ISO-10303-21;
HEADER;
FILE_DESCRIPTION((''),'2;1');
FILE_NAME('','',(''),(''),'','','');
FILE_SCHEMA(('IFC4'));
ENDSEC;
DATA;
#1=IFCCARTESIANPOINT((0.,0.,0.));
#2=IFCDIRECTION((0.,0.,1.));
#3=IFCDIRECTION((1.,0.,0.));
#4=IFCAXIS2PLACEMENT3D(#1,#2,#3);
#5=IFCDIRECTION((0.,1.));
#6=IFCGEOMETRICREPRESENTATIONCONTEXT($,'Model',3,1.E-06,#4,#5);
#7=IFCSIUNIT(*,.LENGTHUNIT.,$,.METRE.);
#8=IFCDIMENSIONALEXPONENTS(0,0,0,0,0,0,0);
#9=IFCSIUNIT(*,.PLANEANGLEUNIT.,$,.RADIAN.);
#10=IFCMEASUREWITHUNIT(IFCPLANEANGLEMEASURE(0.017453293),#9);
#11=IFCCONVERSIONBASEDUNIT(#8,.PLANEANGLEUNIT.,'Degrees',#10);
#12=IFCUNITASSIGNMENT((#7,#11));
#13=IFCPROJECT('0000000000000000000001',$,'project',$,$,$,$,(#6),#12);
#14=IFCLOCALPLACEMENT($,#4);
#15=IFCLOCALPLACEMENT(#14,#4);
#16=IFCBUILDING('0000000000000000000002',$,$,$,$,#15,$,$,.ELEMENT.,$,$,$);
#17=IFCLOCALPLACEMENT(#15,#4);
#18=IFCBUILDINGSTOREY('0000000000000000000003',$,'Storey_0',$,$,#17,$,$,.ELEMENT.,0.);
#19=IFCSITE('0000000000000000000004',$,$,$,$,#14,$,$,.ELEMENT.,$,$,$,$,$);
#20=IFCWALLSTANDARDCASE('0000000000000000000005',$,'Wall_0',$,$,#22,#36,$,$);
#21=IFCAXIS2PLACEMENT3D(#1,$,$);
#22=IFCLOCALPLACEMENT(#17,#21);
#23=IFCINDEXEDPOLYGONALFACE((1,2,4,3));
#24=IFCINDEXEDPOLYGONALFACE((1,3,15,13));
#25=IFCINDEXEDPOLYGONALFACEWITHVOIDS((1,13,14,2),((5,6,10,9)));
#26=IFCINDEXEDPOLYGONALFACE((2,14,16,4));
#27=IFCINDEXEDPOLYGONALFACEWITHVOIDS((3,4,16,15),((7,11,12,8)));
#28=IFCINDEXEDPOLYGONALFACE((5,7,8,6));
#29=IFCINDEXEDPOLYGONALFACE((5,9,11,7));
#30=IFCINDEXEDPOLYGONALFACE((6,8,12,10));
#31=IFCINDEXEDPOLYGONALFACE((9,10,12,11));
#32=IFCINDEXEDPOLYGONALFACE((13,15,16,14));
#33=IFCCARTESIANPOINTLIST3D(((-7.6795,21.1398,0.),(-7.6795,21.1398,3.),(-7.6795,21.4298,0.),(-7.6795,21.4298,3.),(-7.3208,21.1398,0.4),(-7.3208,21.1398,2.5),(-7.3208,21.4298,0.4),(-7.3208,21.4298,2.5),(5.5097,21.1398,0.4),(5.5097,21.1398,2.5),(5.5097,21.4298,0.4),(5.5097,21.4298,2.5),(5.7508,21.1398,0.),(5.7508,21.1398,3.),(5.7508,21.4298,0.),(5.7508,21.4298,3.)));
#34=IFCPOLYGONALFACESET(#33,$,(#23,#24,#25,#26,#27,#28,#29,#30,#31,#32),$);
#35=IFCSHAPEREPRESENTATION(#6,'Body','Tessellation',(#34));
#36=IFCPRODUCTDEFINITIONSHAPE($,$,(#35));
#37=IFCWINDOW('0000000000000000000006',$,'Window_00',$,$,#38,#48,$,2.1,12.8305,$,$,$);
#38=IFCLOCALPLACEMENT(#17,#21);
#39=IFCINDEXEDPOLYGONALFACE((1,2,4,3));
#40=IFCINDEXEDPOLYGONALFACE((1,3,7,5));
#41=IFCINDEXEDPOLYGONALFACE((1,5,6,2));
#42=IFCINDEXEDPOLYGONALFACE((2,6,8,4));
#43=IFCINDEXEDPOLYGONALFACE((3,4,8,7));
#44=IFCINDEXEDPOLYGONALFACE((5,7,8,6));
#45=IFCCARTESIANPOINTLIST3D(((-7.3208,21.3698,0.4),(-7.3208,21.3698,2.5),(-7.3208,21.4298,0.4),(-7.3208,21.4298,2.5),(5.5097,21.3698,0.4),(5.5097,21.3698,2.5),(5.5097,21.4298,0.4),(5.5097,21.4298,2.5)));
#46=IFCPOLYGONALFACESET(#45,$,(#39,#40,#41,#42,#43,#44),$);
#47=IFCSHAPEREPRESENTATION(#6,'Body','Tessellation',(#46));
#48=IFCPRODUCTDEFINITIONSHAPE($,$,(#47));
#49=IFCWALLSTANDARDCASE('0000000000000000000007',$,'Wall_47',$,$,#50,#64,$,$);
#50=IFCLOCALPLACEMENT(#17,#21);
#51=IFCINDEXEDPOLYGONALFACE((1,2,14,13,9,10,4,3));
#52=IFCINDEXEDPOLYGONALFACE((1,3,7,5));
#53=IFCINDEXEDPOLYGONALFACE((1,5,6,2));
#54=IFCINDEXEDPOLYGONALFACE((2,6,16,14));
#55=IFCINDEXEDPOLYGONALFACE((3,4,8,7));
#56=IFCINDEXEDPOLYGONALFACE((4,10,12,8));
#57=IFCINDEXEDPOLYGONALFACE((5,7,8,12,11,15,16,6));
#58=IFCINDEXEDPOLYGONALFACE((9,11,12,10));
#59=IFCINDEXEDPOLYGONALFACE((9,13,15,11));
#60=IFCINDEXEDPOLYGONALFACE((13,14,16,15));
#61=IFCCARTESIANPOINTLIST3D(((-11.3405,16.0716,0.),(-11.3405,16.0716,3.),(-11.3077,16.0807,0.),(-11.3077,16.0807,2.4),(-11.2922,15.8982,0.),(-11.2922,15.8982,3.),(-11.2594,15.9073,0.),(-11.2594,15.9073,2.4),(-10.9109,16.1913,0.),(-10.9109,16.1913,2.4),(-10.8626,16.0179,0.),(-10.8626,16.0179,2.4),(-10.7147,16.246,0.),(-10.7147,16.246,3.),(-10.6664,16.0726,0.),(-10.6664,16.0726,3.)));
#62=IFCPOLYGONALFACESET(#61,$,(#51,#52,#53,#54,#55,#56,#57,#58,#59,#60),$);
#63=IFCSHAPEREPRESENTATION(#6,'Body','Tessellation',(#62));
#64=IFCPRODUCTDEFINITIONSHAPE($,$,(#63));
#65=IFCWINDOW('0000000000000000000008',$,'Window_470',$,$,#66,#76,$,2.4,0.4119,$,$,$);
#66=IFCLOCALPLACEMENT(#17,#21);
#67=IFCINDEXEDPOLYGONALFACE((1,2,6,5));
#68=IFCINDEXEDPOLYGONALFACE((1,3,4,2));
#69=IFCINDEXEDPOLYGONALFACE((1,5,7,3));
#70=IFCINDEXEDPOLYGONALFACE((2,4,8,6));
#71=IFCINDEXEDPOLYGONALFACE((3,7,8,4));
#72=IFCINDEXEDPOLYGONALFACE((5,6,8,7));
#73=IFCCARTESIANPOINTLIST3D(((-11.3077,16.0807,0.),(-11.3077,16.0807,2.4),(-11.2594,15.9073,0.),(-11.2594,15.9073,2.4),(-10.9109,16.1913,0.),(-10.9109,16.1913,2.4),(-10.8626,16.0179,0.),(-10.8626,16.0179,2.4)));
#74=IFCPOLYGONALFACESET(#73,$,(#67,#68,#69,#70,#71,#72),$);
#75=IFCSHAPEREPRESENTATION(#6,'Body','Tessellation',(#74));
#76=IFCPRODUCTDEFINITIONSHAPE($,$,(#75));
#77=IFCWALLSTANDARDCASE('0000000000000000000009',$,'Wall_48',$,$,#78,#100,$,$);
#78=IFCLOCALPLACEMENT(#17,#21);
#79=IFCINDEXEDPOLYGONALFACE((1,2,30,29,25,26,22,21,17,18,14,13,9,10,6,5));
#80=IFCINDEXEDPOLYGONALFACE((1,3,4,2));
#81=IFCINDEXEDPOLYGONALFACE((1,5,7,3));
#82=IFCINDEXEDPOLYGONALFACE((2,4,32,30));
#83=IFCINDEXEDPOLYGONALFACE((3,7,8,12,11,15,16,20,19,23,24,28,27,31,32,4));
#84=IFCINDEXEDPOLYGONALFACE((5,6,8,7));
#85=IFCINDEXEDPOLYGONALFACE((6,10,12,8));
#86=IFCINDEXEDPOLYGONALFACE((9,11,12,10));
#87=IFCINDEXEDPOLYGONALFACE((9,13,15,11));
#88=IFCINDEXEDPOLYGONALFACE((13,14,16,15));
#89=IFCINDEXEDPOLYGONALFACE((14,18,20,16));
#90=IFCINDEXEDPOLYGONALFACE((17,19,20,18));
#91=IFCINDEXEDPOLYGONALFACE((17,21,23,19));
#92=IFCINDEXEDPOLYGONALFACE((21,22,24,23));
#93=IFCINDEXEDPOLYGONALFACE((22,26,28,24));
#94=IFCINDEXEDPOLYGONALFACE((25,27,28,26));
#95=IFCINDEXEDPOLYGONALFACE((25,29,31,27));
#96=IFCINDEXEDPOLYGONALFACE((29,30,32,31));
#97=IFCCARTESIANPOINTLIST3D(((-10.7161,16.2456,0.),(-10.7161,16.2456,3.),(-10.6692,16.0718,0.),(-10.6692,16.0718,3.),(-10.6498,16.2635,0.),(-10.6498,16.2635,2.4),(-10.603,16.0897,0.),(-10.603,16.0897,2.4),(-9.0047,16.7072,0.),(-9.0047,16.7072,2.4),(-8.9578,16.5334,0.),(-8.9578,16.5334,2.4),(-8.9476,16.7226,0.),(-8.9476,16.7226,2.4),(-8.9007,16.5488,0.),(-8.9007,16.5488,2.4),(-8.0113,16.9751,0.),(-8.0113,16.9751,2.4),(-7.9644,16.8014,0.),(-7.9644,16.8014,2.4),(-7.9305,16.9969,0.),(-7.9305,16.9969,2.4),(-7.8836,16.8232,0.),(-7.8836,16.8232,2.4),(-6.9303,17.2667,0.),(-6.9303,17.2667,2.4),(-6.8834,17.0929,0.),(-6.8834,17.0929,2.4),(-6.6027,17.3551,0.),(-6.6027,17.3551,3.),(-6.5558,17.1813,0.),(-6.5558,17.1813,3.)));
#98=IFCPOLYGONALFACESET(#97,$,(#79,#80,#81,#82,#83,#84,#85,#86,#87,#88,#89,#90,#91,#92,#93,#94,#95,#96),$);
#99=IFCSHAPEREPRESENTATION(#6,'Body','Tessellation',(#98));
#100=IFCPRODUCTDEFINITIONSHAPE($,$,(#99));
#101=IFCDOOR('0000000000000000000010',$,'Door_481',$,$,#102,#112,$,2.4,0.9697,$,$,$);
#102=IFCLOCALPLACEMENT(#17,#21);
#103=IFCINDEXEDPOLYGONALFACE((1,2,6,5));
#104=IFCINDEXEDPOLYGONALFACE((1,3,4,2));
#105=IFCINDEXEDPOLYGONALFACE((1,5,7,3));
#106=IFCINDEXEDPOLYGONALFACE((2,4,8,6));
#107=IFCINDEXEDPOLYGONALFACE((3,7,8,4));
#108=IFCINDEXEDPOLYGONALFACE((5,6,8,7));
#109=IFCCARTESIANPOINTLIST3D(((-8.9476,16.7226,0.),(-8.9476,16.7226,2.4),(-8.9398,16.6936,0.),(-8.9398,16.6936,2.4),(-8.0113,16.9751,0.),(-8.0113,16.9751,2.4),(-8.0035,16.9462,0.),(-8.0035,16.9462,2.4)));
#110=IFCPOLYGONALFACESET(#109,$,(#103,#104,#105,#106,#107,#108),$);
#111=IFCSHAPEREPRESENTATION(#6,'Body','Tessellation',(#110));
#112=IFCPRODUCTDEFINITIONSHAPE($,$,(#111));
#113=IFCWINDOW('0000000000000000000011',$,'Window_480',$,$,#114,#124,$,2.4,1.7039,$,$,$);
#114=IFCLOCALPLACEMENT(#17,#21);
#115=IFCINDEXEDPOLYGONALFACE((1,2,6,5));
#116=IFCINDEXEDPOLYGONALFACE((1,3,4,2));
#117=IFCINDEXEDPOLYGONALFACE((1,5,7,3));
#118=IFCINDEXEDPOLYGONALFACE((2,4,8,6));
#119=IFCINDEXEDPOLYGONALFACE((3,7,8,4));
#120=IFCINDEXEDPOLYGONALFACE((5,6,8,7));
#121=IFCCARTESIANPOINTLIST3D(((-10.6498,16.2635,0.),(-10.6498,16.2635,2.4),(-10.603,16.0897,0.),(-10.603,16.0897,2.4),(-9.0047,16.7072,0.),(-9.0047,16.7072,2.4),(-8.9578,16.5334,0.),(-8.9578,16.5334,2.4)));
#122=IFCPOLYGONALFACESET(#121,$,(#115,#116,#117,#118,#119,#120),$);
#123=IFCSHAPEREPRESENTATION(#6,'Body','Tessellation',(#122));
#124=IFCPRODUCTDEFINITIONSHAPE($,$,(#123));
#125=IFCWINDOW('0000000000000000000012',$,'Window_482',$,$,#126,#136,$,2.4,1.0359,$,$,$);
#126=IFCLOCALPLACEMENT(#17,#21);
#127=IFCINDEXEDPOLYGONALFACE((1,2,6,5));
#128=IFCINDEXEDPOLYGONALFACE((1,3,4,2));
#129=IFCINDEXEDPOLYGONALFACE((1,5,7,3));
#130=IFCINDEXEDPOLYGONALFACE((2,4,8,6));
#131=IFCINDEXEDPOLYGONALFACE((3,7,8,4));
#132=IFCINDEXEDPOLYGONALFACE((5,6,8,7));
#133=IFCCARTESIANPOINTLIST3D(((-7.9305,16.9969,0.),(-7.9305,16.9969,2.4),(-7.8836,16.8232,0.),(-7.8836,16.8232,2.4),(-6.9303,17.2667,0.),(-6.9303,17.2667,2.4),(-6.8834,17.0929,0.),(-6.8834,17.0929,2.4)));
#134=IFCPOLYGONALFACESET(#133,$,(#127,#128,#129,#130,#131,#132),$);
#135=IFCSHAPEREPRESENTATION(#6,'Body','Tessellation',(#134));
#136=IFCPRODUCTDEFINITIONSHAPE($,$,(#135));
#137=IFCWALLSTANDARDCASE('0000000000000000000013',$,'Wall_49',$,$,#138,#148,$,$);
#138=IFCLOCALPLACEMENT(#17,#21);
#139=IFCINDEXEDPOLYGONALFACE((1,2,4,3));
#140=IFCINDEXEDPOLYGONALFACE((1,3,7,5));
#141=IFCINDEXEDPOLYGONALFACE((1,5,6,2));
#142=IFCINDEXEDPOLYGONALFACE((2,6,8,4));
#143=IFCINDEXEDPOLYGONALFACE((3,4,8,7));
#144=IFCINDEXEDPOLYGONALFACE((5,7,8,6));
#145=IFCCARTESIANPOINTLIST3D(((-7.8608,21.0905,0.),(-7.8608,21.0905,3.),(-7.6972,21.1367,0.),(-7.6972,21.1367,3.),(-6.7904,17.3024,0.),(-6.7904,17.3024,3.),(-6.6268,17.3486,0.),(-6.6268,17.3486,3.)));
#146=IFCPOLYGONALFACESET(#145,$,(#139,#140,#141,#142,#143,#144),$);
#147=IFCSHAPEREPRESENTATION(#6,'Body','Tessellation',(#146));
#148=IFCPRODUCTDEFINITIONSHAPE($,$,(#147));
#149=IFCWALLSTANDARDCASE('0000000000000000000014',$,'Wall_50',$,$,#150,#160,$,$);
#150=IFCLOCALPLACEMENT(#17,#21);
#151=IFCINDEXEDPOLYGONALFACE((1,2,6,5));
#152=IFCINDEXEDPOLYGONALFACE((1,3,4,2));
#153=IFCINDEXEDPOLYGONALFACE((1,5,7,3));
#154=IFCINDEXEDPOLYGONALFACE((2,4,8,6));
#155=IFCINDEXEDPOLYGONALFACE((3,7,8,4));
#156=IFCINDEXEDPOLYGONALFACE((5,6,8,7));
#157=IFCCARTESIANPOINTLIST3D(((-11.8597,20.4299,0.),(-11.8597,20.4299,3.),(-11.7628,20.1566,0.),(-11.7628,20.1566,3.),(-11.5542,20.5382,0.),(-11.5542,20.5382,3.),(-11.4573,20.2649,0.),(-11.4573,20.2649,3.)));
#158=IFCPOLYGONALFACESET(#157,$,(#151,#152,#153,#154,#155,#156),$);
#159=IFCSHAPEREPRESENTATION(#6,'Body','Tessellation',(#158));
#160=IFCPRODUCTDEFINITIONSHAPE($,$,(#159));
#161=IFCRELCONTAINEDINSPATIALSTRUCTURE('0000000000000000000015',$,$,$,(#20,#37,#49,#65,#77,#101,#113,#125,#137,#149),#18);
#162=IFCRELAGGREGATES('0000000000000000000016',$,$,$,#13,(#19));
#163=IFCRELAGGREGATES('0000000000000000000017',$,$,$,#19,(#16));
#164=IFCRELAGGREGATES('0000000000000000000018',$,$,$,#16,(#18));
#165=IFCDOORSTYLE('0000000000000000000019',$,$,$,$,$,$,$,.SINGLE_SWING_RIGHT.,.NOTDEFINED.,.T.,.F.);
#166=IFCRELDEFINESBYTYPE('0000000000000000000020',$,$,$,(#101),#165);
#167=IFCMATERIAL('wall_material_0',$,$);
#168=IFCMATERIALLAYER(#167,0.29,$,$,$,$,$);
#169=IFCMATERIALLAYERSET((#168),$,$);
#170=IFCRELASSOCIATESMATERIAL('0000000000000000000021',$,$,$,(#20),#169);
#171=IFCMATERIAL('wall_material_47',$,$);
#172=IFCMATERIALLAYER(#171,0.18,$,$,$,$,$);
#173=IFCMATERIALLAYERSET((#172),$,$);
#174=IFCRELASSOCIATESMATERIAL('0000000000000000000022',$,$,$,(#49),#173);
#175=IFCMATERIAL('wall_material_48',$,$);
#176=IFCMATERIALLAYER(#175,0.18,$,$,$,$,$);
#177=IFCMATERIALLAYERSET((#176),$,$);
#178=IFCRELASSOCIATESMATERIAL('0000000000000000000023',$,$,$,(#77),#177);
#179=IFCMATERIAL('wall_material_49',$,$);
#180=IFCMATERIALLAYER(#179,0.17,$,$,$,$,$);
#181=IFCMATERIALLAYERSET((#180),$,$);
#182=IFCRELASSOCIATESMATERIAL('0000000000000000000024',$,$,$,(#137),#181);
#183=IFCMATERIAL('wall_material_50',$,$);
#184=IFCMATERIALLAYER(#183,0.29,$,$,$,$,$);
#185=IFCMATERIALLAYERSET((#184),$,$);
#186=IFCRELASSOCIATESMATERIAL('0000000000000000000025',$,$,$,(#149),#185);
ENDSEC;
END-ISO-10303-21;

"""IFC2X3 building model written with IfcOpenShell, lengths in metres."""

from ifc_helpers import new_model, entity, si_unit, converted_unit, direction, frame, frame_2d, origin_with_axes, place, context, project, spatial, polyline, rectangle, outline, extrude, material, layer, layer_set, layer_usage, type_object, element, fill, save


model = new_model("IFC2X3")

# Units and contexts
model_context = context("Model", 3, precision=1e-06, world=origin_with_axes(), true_north=direction((0.0, 1.0)))
ifc_project = project(units=[si_unit("LENGTHUNIT", "METRE"), converted_unit("PLANEANGLEUNIT", "Degrees", entity("IfcPlaneAngleMeasure", 0.017453293), si_unit("PLANEANGLEUNIT", "RADIAN"), dimensions=[0, 0, 0, 0, 0, 0, 0])], contexts=[model_context])

# Site, building, storey
site_placement = place(None, origin_with_axes())
site = spatial("IfcSite", under=ifc_project, at=site_placement, CompositionType="ELEMENT")
building_placement = place(site_placement, origin_with_axes())
building = spatial("IfcBuilding", under=site, at=building_placement, CompositionType="ELEMENT")
storey_placement = place(building_placement, origin_with_axes())
storey = spatial("IfcBuildingStorey", under=building, at=storey_placement, Name="Storey_0", CompositionType="ELEMENT", Elevation=0.0)

# Walls, openings, windows
ifc_material_1 = material(Name="wall_material_0")
ifc_layer_1 = layer(ifc_material_1, 0.29)
ifc_layer_set_1 = layer_set([ifc_layer_1])
ifc_layer_usage_1 = layer_usage(ifc_layer_set_1, "AXIS2", "NEGATIVE", 0.0)
wall_1_placement = place(storey_placement, frame((-7.6795, 21.4298, 0.0), z_axis=(0.0, 0.0, 1.0), x_axis=(1.0, 0.0, 0.0)))
wall_1 = element("IfcWallStandardCase", 1, at=wall_1_placement, inside=storey, material=ifc_layer_usage_1, Name="Wall_0", context=model_context, shape_type="SweptSolid", body=[
    extrude(outline(polyline([(0.0, 0.0), (13.4303, 0.0), (13.4303, -0.29), (0.0, -0.29), (0.0, 0.0)])), origin_with_axes(), (0.0, 0.0, 1.0), 3.0),
])
opening_1_placement = place(wall_1_placement, frame((0.3587, 0.0, 0.4), z_axis=(0.0, 0.0, 1.0), x_axis=(1.0, 0.0, 0.0)))
opening_1 = element("IfcOpeningElement", 2, at=opening_1_placement, cuts=wall_1, context=model_context, shape_type="SweptSolid", body=[
    extrude(rectangle(XDim=12.8305, YDim=2.1, at=frame_2d((1.05, -6.4152), x_axis=(0.0, 1.0))), frame((0.0, 0.01, 0.0), z_axis=(0.0, -1.0, 0.0), x_axis=(0.0, 0.0, 1.0)), (0.0, 0.0, 1.0), 0.31),
])
window_1_placement = place(storey_placement, frame((0.0, 0.0, 0.4), z_axis=(0.0, 0.0, 1.0), x_axis=(1.0, 0.0, 0.0)))
window_1 = element("IfcWindow", 3, at=window_1_placement, inside=storey, Name="Window_00", OverallHeight=2.1, OverallWidth=12.8305, context=model_context, shape_type="SweptSolid", body=[
    extrude(outline(polyline([(-7.3208, 21.4298), (5.5097, 21.4298), (5.5097, 21.3698), (-7.3208, 21.3698), (-7.3208, 21.4298)])), origin_with_axes(), (0.0, 0.0, 1.0), 2.1),
])
fill(opening_1, window_1)
ifc_material_2 = material(Name="wall_material_47")
ifc_layer_2 = layer(ifc_material_2, 0.18)
ifc_layer_set_2 = layer_set([ifc_layer_2])
ifc_layer_usage_2 = layer_usage(ifc_layer_set_2, "AXIS2", "POSITIVE", 0.0)
wall_2_placement = place(storey_placement, frame((-11.2922, 15.8982, 0.0), z_axis=(0.0, 0.0, 1.0), x_axis=(0.96329, 0.268463, 0.0)))
wall_2 = element("IfcWallStandardCase", 4, at=wall_2_placement, inside=storey, material=ifc_layer_usage_2, Name="Wall_47", context=model_context, shape_type="SweptSolid", body=[
    extrude(outline(polyline([(0.0, 0.18), (0.6497, 0.18), (0.6497, 0.0), (0.0, 0.0), (0.0, 0.18)])), origin_with_axes(), (0.0, 0.0, 1.0), 3.0),
])
opening_2_placement = place(wall_2_placement, frame((0.0341, 0.18, 0.0), z_axis=(0.0, 0.0, 1.0), x_axis=(1.0, 0.0, 0.0)))
opening_2 = element("IfcOpeningElement", 5, at=opening_2_placement, cuts=wall_2, context=model_context, shape_type="SweptSolid", body=[
    extrude(rectangle(XDim=0.4119, YDim=2.4, at=frame_2d((1.2, -0.2059), x_axis=(0.0, 1.0))), frame((0.0, 0.01, 0.0), z_axis=(0.0, -1.0, 0.0), x_axis=(0.0, 0.0, 1.0)), (0.0, 0.0, 1.0), 0.2),
])
window_2_placement = place(storey_placement, origin_with_axes())
window_2 = element("IfcWindow", 6, at=window_2_placement, inside=storey, Name="Window_470", OverallHeight=2.4, OverallWidth=0.4119, context=model_context, shape_type="SweptSolid", body=[
    extrude(outline(polyline([(-11.3077, 16.0807), (-10.9109, 16.1913), (-10.8626, 16.0179), (-11.2594, 15.9073), (-11.3077, 16.0807)])), origin_with_axes(), (0.0, 0.0, 1.0), 2.4),
])
fill(opening_2, window_2)

# Wall, openings, door, windows
ifc_material_3 = material(Name="wall_material_48")
ifc_layer_3 = layer(ifc_material_3, 0.18)
ifc_layer_set_3 = layer_set([ifc_layer_3])
ifc_layer_usage_3 = layer_usage(ifc_layer_set_3, "AXIS2", "POSITIVE", 0.0)
wall_3_placement = place(storey_placement, frame((-10.6692, 16.0718, 0.0), z_axis=(0.0, 0.0, 1.0), x_axis=(0.965495, 0.260421, 0.0)))
wall_3 = element("IfcWallStandardCase", 7, at=wall_3_placement, inside=storey, material=ifc_layer_usage_3, Name="Wall_48", context=model_context, shape_type="SweptSolid", body=[
    extrude(outline(polyline([(0.0, 0.18), (4.2605, 0.18), (4.2605, 0.0), (0.0, 0.0), (0.0, 0.18)])), origin_with_axes(), (0.0, 0.0, 1.0), 3.0),
])
opening_3_placement = place(wall_3_placement, frame((0.0687, 0.18, 0.0), z_axis=(0.0, 0.0, 1.0), x_axis=(1.0, 0.0, 0.0)))
opening_3 = element("IfcOpeningElement", 8, at=opening_3_placement, cuts=wall_3, context=model_context, shape_type="SweptSolid", body=[
    extrude(rectangle(XDim=1.7039, YDim=2.4, at=frame_2d((1.2, -0.852), x_axis=(0.0, 1.0))), frame((0.0, 0.01, 0.0), z_axis=(0.0, -1.0, 0.0), x_axis=(0.0, 0.0, 1.0)), (0.0, 0.0, 1.0), 0.2),
])
opening_4_placement = place(wall_3_placement, frame((1.8318, 0.18, 0.0), z_axis=(0.0, 0.0, 1.0), x_axis=(1.0, 0.0, 0.0)))
opening_4 = element("IfcOpeningElement", 9, at=opening_4_placement, cuts=wall_3, context=model_context, shape_type="SweptSolid", body=[
    extrude(rectangle(XDim=0.9697, YDim=2.4, at=frame_2d((1.2, -0.4849), x_axis=(0.0, 1.0))), frame((0.0, 0.01, 0.0), z_axis=(0.0, -1.0, 0.0), x_axis=(0.0, 0.0, 1.0)), (0.0, 0.0, 1.0), 0.2),
])
opening_5_placement = place(wall_3_placement, frame((2.8852, 0.18, 0.0), z_axis=(0.0, 0.0, 1.0), x_axis=(1.0, 0.0, 0.0)))
opening_5 = element("IfcOpeningElement", 10, at=opening_5_placement, cuts=wall_3, context=model_context, shape_type="SweptSolid", body=[
    extrude(rectangle(XDim=1.0359, YDim=2.4, at=frame_2d((1.2, -0.518), x_axis=(0.0, 1.0))), frame((0.0, 0.01, 0.0), z_axis=(0.0, -1.0, 0.0), x_axis=(0.0, 0.0, 1.0)), (0.0, 0.0, 1.0), 0.2),
])
door_style_1 = type_object("IfcDoorStyle", ConstructionType="NOTDEFINED", OperationType="SINGLE_SWING_RIGHT", ParameterTakesPrecedence=True, Sizeable=False)
door_1_placement = place(storey_placement, origin_with_axes())
door_1 = element("IfcDoor", 11, at=door_1_placement, inside=storey, type_object=door_style_1, Name="Door_481", OverallHeight=2.4, OverallWidth=0.9697, context=model_context, shape_type="SweptSolid", body=[
    extrude(outline(polyline([(-8.9476, 16.7226), (-8.0113, 16.9751), (-8.0035, 16.9462), (-8.9398, 16.6936), (-8.9476, 16.7226)])), origin_with_axes(), (0.0, 0.0, 1.0), 2.4),
])
fill(opening_4, door_1)
window_3_placement = place(storey_placement, origin_with_axes())
window_3 = element("IfcWindow", 12, at=window_3_placement, inside=storey, Name="Window_480", OverallHeight=2.4, OverallWidth=1.7039, context=model_context, shape_type="SweptSolid", body=[
    extrude(outline(polyline([(-10.6498, 16.2635), (-9.0047, 16.7072), (-8.9578, 16.5334), (-10.603, 16.0897), (-10.6498, 16.2635)])), origin_with_axes(), (0.0, 0.0, 1.0), 2.4),
])
fill(opening_3, window_3)
window_4_placement = place(storey_placement, origin_with_axes())
window_4 = element("IfcWindow", 13, at=window_4_placement, inside=storey, Name="Window_482", OverallHeight=2.4, OverallWidth=1.0359, context=model_context, shape_type="SweptSolid", body=[
    extrude(outline(polyline([(-7.9305, 16.9969), (-6.9303, 17.2667), (-6.8834, 17.0929), (-7.8836, 16.8232), (-7.9305, 16.9969)])), origin_with_axes(), (0.0, 0.0, 1.0), 2.4),
])
fill(opening_5, window_4)

# Walls
ifc_material_4 = material(Name="wall_material_49")
ifc_layer_4 = layer(ifc_material_4, 0.17)
ifc_layer_set_4 = layer_set([ifc_layer_4])
ifc_layer_usage_4 = layer_usage(ifc_layer_set_4, "AXIS2", "NEGATIVE", 0.0)
wall_4_placement = place(storey_placement, frame((-7.6972, 21.1367, 0.0), z_axis=(0.0, 0.0, 1.0), x_axis=(0.271919, -0.96232, 0.0)))
element("IfcWallStandardCase", 14, at=wall_4_placement, inside=storey, material=ifc_layer_usage_4, Name="Wall_49", context=model_context, shape_type="SweptSolid", body=[
    extrude(outline(polyline([(0.0, 0.0), (3.9365, 0.0), (3.9365, -0.17), (0.0, -0.17), (0.0, 0.0)])), origin_with_axes(), (0.0, 0.0, 1.0), 3.0),
])
ifc_material_5 = material(Name="wall_material_50")
ifc_layer_5 = layer(ifc_material_5, 0.29)
ifc_layer_set_5 = layer_set([ifc_layer_5])
ifc_layer_usage_5 = layer_usage(ifc_layer_set_5, "AXIS2", "NEGATIVE", 0.0)
wall_5_placement = place(storey_placement, frame((-11.8597, 20.4299, 0.0), z_axis=(0.0, 0.0, 1.0), x_axis=(0.942523, 0.334141, 0.0)))
element("IfcWallStandardCase", 15, at=wall_5_placement, inside=storey, material=ifc_layer_usage_5, Name="Wall_50", context=model_context, shape_type="SweptSolid", body=[
    extrude(outline(polyline([(0.0, 0.0), (0.3241, 0.0), (0.3241, -0.29), (0.0, -0.29), (0.0, 0.0)])), origin_with_axes(), (0.0, 0.0, 1.0), 3.0),
])

save(model, "model.ifc")
